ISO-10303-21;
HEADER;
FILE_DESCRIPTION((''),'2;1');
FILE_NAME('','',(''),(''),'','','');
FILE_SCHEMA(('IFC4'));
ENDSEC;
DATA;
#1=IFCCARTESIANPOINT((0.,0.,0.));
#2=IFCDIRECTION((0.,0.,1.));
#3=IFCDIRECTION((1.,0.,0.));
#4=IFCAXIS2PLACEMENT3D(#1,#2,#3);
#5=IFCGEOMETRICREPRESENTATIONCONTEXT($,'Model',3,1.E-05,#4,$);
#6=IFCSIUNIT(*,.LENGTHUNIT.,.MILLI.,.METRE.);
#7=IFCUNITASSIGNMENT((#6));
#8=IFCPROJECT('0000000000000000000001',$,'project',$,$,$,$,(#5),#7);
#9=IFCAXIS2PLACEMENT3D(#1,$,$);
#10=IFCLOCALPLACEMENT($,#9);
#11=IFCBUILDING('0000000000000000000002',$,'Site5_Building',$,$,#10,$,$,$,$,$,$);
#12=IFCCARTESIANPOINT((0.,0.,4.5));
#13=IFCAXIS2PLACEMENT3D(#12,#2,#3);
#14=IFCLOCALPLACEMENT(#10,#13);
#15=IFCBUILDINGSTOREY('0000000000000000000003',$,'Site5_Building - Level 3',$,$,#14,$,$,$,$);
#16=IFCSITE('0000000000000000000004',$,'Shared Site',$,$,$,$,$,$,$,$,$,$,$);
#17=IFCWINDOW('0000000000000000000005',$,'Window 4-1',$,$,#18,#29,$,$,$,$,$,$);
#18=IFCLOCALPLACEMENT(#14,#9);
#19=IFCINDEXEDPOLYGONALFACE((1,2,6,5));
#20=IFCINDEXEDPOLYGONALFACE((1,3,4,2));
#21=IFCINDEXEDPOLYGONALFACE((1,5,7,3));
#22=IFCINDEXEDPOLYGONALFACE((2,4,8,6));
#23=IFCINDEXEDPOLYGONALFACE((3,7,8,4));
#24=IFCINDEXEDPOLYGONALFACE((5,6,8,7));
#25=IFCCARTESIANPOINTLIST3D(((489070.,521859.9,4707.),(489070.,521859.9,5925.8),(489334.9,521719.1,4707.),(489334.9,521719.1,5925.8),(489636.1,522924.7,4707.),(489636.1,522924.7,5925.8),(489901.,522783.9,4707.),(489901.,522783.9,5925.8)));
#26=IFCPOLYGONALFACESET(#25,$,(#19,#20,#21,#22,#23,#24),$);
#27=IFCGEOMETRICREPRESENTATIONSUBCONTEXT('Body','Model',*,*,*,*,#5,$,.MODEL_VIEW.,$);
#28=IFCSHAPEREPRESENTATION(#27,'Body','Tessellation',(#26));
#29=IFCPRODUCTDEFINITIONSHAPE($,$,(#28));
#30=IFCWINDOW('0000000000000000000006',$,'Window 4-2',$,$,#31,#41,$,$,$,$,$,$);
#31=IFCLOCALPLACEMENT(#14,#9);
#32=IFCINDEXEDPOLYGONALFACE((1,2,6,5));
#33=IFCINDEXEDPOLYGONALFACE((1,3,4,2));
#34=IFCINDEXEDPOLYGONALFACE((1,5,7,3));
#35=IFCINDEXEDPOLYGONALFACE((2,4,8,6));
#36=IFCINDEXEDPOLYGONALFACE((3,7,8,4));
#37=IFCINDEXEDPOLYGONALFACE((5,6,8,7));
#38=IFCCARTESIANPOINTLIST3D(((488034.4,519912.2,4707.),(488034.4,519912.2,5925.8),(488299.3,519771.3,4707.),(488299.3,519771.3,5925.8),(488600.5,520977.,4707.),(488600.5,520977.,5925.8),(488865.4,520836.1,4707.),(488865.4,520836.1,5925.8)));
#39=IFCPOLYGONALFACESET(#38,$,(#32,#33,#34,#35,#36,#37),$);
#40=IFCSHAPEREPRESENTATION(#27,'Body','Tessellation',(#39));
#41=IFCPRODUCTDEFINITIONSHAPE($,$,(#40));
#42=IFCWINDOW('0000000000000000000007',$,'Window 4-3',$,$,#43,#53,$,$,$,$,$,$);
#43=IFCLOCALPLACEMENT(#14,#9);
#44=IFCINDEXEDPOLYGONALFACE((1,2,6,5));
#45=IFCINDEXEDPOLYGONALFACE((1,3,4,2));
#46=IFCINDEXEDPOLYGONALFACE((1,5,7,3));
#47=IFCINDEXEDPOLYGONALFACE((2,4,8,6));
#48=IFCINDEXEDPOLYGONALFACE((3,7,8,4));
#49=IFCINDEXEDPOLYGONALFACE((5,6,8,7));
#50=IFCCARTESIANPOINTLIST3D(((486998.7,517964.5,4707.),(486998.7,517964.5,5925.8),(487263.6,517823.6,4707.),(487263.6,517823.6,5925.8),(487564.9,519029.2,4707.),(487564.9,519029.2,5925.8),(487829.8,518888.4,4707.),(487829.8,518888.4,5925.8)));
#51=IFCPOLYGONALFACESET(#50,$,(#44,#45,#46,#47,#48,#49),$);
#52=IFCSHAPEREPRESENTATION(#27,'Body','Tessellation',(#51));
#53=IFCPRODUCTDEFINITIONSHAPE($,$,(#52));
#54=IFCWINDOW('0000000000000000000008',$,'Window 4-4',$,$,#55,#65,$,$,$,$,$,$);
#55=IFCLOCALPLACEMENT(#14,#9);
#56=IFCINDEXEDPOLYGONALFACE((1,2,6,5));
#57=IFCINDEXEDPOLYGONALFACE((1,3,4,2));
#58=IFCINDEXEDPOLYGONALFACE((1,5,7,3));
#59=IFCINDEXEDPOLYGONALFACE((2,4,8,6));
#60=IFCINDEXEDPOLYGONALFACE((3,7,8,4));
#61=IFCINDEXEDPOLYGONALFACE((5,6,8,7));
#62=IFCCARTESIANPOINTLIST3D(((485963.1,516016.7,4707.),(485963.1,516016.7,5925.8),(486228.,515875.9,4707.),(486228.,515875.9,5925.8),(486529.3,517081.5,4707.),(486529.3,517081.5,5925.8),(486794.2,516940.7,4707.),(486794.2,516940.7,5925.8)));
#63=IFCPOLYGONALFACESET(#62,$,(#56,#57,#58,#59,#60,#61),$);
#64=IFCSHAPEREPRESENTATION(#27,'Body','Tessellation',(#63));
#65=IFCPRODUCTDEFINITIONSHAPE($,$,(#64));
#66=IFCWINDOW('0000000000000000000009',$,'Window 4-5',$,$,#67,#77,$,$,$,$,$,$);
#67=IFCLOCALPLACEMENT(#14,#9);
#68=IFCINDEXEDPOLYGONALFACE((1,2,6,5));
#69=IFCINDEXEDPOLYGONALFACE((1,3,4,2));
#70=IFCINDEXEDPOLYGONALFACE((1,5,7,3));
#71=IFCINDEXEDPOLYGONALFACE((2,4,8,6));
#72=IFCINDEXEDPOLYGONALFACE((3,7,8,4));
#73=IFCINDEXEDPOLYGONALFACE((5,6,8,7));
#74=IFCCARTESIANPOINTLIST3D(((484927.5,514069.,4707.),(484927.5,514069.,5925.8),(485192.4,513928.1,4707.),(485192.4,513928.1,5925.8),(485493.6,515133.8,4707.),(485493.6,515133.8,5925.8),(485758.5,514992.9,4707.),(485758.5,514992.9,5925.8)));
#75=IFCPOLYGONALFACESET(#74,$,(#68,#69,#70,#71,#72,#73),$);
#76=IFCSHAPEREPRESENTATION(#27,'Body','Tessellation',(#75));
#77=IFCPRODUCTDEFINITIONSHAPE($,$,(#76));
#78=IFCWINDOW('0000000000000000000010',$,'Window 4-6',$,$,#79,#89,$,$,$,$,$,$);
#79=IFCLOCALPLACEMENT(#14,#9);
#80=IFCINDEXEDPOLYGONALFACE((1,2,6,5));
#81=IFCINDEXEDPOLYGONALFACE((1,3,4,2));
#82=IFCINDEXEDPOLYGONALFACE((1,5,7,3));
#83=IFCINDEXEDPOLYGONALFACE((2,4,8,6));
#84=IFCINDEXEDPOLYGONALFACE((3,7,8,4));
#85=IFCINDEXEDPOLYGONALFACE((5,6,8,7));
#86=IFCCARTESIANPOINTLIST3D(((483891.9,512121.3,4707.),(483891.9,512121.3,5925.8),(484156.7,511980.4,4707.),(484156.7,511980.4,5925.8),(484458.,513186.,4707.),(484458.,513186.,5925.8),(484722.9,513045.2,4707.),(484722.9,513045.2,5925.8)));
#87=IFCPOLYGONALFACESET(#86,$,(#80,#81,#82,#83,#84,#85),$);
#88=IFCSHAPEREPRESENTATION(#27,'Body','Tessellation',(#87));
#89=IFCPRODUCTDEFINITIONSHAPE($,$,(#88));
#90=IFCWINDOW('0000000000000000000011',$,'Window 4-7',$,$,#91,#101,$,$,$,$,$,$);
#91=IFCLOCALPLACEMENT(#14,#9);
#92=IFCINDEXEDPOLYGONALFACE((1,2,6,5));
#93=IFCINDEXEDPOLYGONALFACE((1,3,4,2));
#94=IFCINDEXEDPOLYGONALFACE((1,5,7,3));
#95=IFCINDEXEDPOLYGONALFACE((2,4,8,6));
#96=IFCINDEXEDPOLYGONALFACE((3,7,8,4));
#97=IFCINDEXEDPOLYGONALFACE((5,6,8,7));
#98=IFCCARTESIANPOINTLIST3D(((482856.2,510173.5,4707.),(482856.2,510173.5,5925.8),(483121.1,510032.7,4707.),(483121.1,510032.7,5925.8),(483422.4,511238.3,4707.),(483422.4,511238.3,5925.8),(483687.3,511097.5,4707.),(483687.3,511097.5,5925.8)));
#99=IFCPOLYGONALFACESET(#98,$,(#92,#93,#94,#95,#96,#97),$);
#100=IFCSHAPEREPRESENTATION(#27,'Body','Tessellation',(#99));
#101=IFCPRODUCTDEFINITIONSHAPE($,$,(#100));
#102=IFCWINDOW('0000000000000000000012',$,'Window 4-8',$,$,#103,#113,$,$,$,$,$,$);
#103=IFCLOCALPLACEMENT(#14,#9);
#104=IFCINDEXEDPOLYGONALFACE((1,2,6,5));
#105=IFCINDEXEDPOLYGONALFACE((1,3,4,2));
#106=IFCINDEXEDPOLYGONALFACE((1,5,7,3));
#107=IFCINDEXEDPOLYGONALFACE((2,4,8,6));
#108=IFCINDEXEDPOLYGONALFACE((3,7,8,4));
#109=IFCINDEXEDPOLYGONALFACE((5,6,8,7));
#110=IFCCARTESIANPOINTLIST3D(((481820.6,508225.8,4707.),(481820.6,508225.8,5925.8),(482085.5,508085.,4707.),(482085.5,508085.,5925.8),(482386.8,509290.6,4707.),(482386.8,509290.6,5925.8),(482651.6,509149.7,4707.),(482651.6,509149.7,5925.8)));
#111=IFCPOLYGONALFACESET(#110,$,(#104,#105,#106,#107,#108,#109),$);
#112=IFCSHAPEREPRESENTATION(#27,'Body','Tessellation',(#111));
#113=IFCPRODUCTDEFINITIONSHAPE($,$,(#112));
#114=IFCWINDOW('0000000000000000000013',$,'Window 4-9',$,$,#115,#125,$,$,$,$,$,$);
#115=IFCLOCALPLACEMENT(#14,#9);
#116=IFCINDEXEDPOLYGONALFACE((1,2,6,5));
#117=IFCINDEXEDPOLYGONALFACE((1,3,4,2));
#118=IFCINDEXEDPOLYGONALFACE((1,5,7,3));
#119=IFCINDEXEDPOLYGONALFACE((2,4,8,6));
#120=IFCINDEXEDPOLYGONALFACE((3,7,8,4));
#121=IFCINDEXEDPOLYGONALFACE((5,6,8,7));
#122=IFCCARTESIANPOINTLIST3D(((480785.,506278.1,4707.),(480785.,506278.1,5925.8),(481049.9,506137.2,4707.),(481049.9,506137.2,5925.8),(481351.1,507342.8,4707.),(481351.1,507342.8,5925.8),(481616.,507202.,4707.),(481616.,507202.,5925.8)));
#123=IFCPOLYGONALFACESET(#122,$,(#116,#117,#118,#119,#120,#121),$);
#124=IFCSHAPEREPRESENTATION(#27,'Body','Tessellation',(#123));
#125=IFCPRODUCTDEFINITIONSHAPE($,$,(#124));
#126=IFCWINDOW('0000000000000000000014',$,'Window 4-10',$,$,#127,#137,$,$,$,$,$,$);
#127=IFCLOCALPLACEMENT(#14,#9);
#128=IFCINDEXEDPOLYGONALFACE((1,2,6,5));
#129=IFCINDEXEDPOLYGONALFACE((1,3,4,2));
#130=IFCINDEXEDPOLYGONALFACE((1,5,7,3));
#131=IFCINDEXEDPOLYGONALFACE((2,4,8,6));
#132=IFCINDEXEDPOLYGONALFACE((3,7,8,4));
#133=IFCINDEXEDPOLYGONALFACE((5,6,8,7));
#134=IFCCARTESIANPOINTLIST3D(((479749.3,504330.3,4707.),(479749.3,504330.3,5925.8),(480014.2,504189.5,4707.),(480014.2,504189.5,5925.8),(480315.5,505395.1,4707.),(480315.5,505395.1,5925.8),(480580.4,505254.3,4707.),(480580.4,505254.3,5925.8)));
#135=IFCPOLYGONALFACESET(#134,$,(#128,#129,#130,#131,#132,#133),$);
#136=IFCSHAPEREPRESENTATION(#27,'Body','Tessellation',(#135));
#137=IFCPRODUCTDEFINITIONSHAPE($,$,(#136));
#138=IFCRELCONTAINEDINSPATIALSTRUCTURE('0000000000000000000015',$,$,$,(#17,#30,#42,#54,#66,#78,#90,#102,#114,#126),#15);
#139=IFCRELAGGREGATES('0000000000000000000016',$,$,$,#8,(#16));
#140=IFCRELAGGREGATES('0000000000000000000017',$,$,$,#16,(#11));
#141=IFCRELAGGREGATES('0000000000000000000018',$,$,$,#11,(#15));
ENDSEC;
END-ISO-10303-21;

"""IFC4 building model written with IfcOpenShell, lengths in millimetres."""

from ifc_helpers import new_model, si_unit, frame, origin, origin_with_axes, place, context, subcontext, project, spatial, indexed_curve, outline, extrude, element, save


model = new_model("IFC4")

# Units and contexts
model_context = context("Model", 3, precision=1e-05, world=origin_with_axes())
body_context = subcontext(model_context, "Body", "Model", "MODEL_VIEW")
ifc_project = project(units=[si_unit("LENGTHUNIT", "METRE", prefix="MILLI")], contexts=[model_context])

# Site, building, storey
site = spatial("IfcSite", under=ifc_project, Name="Shared Site")
building_placement = place(None, origin())
building = spatial("IfcBuilding", under=site, at=building_placement, Name="Site5_Building")
storey_placement = place(building_placement, frame((0.0, 0.0, 4.5), z_axis=(0.0, 0.0, 1.0), x_axis=(1.0, 0.0, 0.0)))
storey = spatial("IfcBuildingStorey", under=building, at=storey_placement, Name="Site5_Building - Level 3")

# Windows
for number, where, z_axis, x_axis, name in (
    (1, (489636.1, 522924.7, 4707.0), (0.0, 0.0, 1.0), (-0.469472, -0.882948, 0.0), "Window 4-1"),
    (2, (488600.5, 520977.0, 4707.0), (0.0, 0.0, 1.0), (-0.469472, -0.882948, 0.0), "Window 4-2"),
    (3, (487564.9, 519029.2, 4707.0), (0.0, 0.0, 1.0), (-0.469472, -0.882948, 0.0), "Window 4-3"),
    (4, (486529.3, 517081.5, 4707.0), (0.0, 0.0, 1.0), (-0.469472, -0.882948, 0.0), "Window 4-4"),
    (5, (485493.6, 515133.8, 4707.0), (0.0, 0.0, 1.0), (-0.469472, -0.882948, 0.0), "Window 4-5"),
    (6, (484458.0, 513186.0, 4707.0), (0.0, 0.0, 1.0), (-0.469472, -0.882948, 0.0), "Window 4-6"),
    (7, (483422.4, 511238.3, 4707.0), (0.0, 0.0, 1.0), (-0.469472, -0.882948, 0.0), "Window 4-7"),
    (8, (482386.8, 509290.6, 4707.0), (0.0, 0.0, 1.0), (-0.469472, -0.882948, 0.0), "Window 4-8"),
    (9, (481351.1, 507342.8, 4707.0), (0.0, 0.0, 1.0), (-0.469472, -0.882948, 0.0), "Window 4-9"),
    (10, (480315.5, 505395.1, 4707.0), (0.0, 0.0, 1.0), (-0.469472, -0.882948, 0.0), "Window 4-10"),
):
    element("IfcWindow", number, at=place(storey_placement, frame(where, z_axis=z_axis, x_axis=x_axis)), inside=storey, Name=name, context=body_context, shape_type="SweptSolid", body=[
        extrude(outline(indexed_curve([(0.0, 0.0), (0.0, 300.0), (1205.9, 300.0), (1205.9, 0.0), (0.0, 0.0)], self_intersect=False)), origin_with_axes(), (0.0, 0.0, 1.0), 1218.8),
    ])

save(model, "model.ifc")
